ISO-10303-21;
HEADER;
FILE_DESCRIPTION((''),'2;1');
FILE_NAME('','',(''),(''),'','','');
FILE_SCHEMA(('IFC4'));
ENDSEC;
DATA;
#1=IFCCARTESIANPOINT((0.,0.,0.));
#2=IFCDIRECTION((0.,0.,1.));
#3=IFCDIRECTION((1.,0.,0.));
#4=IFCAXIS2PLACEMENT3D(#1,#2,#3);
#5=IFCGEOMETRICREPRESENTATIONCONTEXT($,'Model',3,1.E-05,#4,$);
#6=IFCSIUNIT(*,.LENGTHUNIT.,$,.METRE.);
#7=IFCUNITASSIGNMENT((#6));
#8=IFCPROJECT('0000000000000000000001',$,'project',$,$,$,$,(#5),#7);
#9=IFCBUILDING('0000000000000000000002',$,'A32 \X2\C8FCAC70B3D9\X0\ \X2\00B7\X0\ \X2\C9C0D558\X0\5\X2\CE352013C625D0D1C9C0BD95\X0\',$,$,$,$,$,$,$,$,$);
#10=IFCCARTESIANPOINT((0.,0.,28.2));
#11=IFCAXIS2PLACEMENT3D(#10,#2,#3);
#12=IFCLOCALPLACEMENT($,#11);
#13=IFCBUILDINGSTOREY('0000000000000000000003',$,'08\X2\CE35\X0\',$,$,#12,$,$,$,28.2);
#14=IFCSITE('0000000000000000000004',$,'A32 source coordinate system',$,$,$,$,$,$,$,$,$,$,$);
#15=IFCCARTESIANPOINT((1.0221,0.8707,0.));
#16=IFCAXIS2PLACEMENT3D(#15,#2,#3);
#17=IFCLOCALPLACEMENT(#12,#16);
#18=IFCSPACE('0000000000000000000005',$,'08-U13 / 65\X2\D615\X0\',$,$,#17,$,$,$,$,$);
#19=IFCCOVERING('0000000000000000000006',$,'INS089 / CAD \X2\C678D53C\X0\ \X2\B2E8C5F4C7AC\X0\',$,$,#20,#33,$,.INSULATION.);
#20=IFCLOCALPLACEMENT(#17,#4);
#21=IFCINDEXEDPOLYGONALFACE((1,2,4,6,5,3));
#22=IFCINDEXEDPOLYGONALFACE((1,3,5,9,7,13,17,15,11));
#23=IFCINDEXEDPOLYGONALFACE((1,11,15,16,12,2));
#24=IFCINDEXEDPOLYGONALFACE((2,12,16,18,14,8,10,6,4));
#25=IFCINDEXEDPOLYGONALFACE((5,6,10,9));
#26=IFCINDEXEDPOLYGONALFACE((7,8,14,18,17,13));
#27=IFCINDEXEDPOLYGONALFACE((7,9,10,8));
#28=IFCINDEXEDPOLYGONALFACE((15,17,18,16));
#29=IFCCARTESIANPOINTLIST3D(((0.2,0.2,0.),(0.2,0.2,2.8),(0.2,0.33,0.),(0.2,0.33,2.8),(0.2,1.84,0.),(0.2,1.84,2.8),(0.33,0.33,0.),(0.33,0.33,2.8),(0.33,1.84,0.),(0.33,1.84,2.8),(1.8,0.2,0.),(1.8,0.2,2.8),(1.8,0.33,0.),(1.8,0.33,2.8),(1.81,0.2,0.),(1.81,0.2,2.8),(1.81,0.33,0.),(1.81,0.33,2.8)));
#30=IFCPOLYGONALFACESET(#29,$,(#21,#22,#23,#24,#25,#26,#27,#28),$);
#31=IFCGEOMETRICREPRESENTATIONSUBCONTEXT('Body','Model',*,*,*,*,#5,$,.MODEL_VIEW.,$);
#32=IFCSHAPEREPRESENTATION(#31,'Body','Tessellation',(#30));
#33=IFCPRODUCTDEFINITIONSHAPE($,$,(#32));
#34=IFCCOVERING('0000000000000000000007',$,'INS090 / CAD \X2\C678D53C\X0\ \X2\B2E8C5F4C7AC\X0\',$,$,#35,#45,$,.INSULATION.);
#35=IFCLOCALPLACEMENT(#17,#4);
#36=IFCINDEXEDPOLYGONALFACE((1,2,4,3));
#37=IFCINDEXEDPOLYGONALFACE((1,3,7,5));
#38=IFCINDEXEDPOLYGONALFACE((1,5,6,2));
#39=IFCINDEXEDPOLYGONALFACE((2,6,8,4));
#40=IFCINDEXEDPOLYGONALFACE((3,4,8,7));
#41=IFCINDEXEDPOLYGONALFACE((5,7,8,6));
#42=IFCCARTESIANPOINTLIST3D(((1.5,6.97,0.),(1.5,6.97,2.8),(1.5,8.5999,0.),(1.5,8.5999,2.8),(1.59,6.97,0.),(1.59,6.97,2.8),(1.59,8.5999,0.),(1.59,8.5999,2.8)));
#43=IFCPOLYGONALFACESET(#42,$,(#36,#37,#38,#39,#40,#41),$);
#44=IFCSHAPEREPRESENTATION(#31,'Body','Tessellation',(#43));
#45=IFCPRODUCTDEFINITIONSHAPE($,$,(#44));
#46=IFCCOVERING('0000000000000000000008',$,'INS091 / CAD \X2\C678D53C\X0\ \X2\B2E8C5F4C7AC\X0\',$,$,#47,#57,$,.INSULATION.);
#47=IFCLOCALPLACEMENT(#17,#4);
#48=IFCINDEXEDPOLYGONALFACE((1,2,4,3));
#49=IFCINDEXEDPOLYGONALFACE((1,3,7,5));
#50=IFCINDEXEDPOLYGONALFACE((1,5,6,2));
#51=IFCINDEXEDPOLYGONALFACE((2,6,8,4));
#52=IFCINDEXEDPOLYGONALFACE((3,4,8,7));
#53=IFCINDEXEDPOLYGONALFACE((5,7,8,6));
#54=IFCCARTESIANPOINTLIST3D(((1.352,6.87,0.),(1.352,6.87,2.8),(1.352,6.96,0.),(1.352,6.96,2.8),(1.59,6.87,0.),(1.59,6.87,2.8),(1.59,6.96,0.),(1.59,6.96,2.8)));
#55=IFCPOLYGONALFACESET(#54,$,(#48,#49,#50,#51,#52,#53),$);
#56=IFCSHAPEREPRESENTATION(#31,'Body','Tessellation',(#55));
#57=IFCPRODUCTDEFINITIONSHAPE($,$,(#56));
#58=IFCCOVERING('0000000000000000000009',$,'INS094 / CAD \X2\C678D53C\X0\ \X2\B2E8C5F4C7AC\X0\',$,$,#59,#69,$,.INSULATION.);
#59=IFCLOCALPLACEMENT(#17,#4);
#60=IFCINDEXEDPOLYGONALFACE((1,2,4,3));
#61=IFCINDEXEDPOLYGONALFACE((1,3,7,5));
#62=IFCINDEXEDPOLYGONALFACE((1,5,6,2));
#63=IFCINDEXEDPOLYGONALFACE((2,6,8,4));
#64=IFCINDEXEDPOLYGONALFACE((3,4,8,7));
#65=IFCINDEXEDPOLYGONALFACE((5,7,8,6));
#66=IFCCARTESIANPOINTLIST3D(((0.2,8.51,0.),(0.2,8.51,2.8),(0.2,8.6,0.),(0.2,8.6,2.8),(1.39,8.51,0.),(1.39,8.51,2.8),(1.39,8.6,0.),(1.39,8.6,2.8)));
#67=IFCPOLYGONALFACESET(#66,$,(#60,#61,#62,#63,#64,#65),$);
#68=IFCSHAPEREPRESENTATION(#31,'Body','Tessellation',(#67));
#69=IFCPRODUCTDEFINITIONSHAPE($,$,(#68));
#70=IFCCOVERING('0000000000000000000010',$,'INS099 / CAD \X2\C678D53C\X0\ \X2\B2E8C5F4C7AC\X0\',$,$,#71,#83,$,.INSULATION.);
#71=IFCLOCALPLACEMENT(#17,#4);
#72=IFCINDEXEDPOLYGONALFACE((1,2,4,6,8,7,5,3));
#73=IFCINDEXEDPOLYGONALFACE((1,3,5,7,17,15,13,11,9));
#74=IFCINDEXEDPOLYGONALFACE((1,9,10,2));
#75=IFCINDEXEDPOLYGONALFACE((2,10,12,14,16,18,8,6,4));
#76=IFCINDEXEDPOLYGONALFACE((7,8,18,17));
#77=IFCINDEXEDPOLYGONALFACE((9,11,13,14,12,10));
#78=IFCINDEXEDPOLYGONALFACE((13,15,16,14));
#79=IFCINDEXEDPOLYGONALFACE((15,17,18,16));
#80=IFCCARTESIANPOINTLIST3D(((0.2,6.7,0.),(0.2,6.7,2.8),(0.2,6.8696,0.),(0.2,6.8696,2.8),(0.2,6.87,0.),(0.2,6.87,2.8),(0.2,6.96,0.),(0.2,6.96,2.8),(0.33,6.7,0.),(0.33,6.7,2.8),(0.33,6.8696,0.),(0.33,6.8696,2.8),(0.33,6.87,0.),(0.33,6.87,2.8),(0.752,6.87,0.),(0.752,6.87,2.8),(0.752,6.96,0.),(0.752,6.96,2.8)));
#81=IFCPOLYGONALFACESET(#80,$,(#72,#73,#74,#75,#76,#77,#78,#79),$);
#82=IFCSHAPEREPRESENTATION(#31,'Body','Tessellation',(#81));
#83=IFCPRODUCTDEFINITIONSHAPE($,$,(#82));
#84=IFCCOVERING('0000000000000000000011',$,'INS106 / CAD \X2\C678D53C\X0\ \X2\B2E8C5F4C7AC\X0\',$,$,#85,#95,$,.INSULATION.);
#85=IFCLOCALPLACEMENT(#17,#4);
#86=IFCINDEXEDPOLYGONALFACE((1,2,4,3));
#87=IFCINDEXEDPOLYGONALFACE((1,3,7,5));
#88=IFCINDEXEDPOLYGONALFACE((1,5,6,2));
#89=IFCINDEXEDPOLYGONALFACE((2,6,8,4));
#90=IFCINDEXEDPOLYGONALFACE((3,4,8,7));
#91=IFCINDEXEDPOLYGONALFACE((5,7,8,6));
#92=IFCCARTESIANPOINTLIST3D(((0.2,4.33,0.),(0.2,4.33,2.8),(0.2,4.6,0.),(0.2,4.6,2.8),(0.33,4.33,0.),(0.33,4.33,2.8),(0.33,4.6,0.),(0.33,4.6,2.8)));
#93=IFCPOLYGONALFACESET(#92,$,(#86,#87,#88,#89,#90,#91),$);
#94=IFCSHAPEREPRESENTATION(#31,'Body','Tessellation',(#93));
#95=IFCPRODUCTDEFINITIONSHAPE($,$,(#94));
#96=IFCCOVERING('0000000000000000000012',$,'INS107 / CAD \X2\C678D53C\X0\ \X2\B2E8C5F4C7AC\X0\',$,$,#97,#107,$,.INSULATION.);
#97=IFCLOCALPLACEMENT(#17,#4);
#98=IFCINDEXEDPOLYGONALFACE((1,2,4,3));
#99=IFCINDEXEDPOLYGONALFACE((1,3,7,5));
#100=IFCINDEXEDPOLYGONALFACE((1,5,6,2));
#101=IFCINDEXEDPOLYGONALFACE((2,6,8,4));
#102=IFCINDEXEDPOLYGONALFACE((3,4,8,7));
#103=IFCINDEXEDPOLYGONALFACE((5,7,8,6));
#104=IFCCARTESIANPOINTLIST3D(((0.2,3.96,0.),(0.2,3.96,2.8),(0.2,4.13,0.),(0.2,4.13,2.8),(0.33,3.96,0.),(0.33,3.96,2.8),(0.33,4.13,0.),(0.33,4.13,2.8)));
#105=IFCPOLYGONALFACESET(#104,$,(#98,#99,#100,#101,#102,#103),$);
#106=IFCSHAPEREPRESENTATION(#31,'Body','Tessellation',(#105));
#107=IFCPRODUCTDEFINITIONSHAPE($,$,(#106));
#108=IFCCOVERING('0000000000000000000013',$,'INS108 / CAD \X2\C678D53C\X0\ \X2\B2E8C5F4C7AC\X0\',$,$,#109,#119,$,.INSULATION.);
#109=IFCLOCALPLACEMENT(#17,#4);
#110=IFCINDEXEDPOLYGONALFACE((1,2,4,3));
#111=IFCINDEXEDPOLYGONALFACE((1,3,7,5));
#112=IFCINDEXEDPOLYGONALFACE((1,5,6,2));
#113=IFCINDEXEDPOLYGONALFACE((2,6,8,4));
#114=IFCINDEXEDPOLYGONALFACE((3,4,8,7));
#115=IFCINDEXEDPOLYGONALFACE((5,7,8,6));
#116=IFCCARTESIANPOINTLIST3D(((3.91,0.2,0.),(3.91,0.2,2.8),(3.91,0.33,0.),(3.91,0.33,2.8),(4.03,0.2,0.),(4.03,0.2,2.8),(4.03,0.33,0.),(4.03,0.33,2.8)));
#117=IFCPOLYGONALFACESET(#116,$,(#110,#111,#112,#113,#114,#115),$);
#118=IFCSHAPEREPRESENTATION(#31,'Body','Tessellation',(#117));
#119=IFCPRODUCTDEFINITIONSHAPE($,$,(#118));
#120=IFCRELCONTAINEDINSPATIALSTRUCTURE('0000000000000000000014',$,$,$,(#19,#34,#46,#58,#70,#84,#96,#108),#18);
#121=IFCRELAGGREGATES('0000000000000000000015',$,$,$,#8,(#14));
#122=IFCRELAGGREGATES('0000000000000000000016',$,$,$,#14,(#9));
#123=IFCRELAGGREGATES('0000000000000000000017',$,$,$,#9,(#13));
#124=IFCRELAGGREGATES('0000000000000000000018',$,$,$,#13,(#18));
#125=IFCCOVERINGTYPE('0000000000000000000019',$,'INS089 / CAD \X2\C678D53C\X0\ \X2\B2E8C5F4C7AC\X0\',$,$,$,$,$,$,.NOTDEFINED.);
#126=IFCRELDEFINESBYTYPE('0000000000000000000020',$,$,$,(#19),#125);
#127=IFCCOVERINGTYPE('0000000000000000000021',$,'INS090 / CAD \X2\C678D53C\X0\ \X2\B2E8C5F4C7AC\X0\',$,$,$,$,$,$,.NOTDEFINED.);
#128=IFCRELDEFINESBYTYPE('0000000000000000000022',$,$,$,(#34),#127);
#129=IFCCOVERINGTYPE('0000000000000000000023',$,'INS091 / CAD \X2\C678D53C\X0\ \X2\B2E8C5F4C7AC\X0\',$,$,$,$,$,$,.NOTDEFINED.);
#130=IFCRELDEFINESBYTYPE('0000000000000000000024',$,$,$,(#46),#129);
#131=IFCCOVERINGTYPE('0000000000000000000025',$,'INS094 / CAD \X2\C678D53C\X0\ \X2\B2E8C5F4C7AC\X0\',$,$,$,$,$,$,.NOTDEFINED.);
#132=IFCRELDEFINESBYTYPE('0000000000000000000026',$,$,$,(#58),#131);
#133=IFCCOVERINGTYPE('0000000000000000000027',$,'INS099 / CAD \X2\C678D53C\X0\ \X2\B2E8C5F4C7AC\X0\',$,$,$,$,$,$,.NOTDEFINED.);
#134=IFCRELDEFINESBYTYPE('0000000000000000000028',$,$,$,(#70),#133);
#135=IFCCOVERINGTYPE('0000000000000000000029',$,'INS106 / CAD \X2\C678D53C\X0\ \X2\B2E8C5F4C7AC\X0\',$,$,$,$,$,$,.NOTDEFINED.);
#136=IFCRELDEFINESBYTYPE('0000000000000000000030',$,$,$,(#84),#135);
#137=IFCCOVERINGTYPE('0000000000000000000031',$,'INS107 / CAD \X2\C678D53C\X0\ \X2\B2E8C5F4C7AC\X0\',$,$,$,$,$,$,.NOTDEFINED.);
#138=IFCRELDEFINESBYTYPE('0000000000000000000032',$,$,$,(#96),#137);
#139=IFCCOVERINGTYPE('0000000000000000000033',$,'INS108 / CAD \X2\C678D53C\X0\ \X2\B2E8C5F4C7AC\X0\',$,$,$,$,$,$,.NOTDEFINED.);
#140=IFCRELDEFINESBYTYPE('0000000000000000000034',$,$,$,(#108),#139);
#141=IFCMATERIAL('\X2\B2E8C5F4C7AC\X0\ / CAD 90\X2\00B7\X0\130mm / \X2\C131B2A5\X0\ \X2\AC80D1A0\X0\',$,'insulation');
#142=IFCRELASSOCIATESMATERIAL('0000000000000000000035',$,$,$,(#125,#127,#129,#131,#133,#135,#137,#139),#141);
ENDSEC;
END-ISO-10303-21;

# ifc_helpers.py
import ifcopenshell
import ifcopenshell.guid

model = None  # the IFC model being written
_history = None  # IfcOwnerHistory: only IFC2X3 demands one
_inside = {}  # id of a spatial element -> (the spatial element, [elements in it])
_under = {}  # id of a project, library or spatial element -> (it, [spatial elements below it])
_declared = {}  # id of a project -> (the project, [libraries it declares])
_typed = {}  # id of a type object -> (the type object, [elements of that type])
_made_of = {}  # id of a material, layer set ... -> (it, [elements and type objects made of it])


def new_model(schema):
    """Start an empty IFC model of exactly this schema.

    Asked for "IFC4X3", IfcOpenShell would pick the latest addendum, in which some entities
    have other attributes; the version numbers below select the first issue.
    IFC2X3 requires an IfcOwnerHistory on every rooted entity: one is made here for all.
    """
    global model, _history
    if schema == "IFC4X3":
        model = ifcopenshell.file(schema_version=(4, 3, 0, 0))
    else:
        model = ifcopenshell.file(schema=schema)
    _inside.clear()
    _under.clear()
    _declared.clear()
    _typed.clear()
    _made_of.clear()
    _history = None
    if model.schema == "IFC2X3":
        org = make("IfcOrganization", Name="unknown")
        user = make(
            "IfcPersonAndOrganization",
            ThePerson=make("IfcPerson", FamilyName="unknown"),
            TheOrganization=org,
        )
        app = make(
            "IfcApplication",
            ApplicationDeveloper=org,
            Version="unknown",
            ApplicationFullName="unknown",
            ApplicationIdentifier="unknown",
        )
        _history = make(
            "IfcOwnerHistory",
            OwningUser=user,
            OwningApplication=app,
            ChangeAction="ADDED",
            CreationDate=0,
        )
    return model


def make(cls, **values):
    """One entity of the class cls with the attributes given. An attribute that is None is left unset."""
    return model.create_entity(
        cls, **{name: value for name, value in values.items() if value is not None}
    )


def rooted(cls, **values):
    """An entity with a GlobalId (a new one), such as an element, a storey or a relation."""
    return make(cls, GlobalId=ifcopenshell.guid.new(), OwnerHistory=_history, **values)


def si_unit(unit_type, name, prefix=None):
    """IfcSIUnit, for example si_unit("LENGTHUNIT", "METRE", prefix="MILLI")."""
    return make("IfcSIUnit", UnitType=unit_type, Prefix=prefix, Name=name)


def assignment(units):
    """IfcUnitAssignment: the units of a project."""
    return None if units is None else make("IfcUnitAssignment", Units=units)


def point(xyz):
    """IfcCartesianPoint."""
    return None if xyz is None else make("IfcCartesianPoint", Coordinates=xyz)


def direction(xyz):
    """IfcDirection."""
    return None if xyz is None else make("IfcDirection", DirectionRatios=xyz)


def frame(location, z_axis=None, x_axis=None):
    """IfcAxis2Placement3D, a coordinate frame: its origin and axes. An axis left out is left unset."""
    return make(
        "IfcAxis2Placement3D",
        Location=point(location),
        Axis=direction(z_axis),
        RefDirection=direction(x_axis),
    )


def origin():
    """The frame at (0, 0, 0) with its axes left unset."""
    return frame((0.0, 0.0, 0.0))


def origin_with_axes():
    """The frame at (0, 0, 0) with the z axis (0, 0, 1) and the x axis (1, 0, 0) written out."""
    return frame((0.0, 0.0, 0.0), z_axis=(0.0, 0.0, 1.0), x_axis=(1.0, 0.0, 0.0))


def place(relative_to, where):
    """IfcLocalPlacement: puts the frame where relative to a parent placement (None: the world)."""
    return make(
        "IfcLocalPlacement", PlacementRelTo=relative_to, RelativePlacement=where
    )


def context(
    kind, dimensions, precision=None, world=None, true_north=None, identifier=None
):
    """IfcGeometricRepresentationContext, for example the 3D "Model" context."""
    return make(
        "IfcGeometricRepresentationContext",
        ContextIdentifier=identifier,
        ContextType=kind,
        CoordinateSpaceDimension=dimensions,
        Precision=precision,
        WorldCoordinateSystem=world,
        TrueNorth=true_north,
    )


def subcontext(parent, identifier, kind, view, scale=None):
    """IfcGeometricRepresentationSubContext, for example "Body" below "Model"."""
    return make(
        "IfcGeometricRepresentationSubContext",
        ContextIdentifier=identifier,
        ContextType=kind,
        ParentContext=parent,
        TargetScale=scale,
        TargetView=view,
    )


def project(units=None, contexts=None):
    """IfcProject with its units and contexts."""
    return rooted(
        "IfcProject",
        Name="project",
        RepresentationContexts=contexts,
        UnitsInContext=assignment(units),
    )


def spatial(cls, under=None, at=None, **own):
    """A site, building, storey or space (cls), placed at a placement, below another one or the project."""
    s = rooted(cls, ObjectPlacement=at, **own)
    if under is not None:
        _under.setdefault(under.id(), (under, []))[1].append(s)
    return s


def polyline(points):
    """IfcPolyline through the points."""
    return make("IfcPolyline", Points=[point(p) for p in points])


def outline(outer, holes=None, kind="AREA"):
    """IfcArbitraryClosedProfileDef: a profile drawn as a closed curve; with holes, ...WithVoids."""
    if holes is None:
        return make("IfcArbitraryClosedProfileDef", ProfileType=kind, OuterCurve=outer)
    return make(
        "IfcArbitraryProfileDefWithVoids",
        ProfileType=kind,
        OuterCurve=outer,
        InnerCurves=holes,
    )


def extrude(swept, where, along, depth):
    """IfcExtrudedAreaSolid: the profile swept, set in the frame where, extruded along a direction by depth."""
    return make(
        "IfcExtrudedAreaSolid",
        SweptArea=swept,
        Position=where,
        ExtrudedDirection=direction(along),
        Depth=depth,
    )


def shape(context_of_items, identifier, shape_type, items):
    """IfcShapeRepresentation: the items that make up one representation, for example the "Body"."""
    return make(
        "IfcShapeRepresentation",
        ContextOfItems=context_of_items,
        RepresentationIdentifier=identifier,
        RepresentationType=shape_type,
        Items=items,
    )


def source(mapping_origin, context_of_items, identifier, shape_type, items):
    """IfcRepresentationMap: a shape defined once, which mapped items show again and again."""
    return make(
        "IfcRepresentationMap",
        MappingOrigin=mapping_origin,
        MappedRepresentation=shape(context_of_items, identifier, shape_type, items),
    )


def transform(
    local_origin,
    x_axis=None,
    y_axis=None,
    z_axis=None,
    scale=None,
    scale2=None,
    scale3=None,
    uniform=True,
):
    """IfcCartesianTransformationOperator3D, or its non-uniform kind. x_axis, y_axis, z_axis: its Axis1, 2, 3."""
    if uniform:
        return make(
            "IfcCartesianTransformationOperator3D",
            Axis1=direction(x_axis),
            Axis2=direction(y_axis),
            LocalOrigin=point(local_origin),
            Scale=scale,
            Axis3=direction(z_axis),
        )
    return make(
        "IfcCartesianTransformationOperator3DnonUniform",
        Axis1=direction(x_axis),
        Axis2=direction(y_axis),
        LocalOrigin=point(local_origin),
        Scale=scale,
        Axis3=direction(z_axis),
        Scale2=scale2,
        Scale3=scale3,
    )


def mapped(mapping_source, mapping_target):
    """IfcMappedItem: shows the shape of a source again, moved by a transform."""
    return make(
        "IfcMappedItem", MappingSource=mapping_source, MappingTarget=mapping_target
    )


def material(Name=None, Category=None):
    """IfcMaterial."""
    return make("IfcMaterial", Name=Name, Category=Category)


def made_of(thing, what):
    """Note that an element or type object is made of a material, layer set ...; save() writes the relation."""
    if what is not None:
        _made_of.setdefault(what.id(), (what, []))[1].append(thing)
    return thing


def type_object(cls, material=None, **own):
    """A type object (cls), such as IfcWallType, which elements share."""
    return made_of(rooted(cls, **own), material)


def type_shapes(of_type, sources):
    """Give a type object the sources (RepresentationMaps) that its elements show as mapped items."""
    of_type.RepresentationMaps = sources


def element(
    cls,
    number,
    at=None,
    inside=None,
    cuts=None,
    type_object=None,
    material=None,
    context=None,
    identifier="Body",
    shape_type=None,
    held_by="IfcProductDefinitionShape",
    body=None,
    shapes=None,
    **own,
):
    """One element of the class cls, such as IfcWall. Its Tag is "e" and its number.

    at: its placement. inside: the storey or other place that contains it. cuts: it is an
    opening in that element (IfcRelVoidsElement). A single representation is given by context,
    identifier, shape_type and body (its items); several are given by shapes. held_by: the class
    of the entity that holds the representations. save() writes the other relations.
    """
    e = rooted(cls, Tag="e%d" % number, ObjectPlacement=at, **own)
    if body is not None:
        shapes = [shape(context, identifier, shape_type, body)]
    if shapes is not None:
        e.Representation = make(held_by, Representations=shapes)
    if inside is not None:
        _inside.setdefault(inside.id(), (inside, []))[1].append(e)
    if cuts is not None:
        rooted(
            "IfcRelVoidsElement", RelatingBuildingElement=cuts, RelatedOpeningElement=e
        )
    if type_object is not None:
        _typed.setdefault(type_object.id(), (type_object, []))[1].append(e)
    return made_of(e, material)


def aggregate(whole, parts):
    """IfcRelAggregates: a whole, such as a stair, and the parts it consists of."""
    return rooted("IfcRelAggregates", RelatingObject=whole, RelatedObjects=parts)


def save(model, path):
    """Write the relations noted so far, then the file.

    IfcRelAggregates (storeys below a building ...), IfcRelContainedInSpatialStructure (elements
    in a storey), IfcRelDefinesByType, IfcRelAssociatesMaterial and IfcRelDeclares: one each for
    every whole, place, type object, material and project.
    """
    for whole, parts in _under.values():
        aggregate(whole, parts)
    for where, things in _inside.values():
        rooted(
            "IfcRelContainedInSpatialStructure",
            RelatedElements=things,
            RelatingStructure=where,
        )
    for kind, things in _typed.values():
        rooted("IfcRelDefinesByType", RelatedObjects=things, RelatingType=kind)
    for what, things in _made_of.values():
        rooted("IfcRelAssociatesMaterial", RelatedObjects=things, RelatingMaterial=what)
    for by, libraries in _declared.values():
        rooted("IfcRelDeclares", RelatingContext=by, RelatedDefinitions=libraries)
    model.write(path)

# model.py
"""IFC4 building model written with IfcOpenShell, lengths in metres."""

from ifc_helpers import new_model, si_unit, frame, origin, origin_with_axes, place, context, subcontext, project, spatial, polyline, outline, extrude, source, transform, mapped, material, type_object, type_shapes, element, save


model = new_model("IFC4")

# Units and contexts
model_context = context("Model", 3, precision=1e-05, world=origin_with_axes())
body_context = subcontext(model_context, "Body", "Model", "MODEL_VIEW")
ifc_project = project(units=[si_unit("LENGTHUNIT", "METRE")], contexts=[model_context])

# Site, building, storey
site = spatial("IfcSite", under=ifc_project, Name="A32 source coordinate system")
building = spatial("IfcBuilding", under=site, Name="A32 주거동 · 지하5층–옥탑지붕")
storey_placement = place(None, frame((0.0, 0.0, 28.2), z_axis=(0.0, 0.0, 1.0), x_axis=(1.0, 0.0, 0.0)))
storey = spatial("IfcBuildingStorey", under=building, at=storey_placement, Name="08층", Elevation=28.2)

# Shared definitions
space_placement = place(storey_placement, frame((1.0221, 0.8707, 0.0), z_axis=(0.0, 0.0, 1.0), x_axis=(1.0, 0.0, 0.0)))
space = spatial("IfcSpace", under=storey, at=space_placement, Name="08-U13 / 65형")

# Coverings
ifc_material = material(Name="단열재 / CAD 90·130mm / 성능 검토", Category="insulation")
covering_type_1 = type_object("IfcCoveringType", Name="INS089 / CAD 외피 단열재", PredefinedType="NOTDEFINED", material=ifc_material)
shared_shape_1 = source(origin(), body_context, "Body", "SweptSolid", [
    extrude(outline(polyline([(0.2, 0.33), (0.2, 1.84), (0.33, 1.84), (0.33, 0.33), (1.8, 0.33), (1.81, 0.33), (1.81, 0.2), (1.8, 0.2), (0.2, 0.2), (0.2, 0.33)])), origin(), (0.0, 0.0, 1.0), 2.8),
])
type_shapes(covering_type_1, [shared_shape_1])
covering_1_placement = place(space_placement, origin_with_axes())
element("IfcCovering", 1, at=covering_1_placement, inside=space, type_object=covering_type_1, Name="INS089 / CAD 외피 단열재", PredefinedType="INSULATION", context=body_context, shape_type="MappedRepresentation", body=[
    mapped(shared_shape_1, transform((0.0, 0.0, 0.0), scale=1.0)),
])
covering_type_2 = type_object("IfcCoveringType", Name="INS090 / CAD 외피 단열재", PredefinedType="NOTDEFINED", material=ifc_material)
shared_shape_2 = source(origin(), body_context, "Body", "SweptSolid", [
    extrude(outline(polyline([(1.59, 6.97), (1.5, 6.97), (1.5, 8.5999), (1.59, 8.5999), (1.59, 6.97)])), origin(), (0.0, 0.0, 1.0), 2.8),
])
type_shapes(covering_type_2, [shared_shape_2])
covering_2_placement = place(space_placement, origin_with_axes())
element("IfcCovering", 2, at=covering_2_placement, inside=space, type_object=covering_type_2, Name="INS090 / CAD 외피 단열재", PredefinedType="INSULATION", context=body_context, shape_type="MappedRepresentation", body=[
    mapped(shared_shape_2, transform((0.0, 0.0, 0.0), scale=1.0)),
])
covering_type_3 = type_object("IfcCoveringType", Name="INS091 / CAD 외피 단열재", PredefinedType="NOTDEFINED", material=ifc_material)
shared_shape_3 = source(origin(), body_context, "Body", "SweptSolid", [
    extrude(outline(polyline([(1.59, 6.96), (1.59, 6.87), (1.352, 6.87), (1.352, 6.96), (1.59, 6.96)])), origin(), (0.0, 0.0, 1.0), 2.8),
])
type_shapes(covering_type_3, [shared_shape_3])
covering_3_placement = place(space_placement, origin_with_axes())
element("IfcCovering", 3, at=covering_3_placement, inside=space, type_object=covering_type_3, Name="INS091 / CAD 외피 단열재", PredefinedType="INSULATION", context=body_context, shape_type="MappedRepresentation", body=[
    mapped(shared_shape_3, transform((0.0, 0.0, 0.0), scale=1.0)),
])
covering_type_4 = type_object("IfcCoveringType", Name="INS094 / CAD 외피 단열재", PredefinedType="NOTDEFINED", material=ifc_material)
shared_shape_4 = source(origin(), body_context, "Body", "SweptSolid", [
    extrude(outline(polyline([(1.39, 8.51), (0.2, 8.51), (0.2, 8.6), (1.39, 8.6), (1.39, 8.51)])), origin(), (0.0, 0.0, 1.0), 2.8),
])
type_shapes(covering_type_4, [shared_shape_4])
covering_4_placement = place(space_placement, origin_with_axes())
element("IfcCovering", 4, at=covering_4_placement, inside=space, type_object=covering_type_4, Name="INS094 / CAD 외피 단열재", PredefinedType="INSULATION", context=body_context, shape_type="MappedRepresentation", body=[
    mapped(shared_shape_4, transform((0.0, 0.0, 0.0), scale=1.0)),
])
covering_type_5 = type_object("IfcCoveringType", Name="INS099 / CAD 외피 단열재", PredefinedType="NOTDEFINED", material=ifc_material)
shared_shape_5 = source(origin(), body_context, "Body", "SweptSolid", [
    extrude(outline(polyline([(0.2, 6.8696), (0.2, 6.87), (0.2, 6.96), (0.752, 6.96), (0.752, 6.87), (0.33, 6.87), (0.33, 6.8696), (0.33, 6.7), (0.2, 6.7), (0.2, 6.8696)])), origin(), (0.0, 0.0, 1.0), 2.8),
])
type_shapes(covering_type_5, [shared_shape_5])
covering_5_placement = place(space_placement, origin_with_axes())
element("IfcCovering", 5, at=covering_5_placement, inside=space, type_object=covering_type_5, Name="INS099 / CAD 외피 단열재", PredefinedType="INSULATION", context=body_context, shape_type="MappedRepresentation", body=[
    mapped(shared_shape_5, transform((0.0, 0.0, 0.0), scale=1.0)),
])
covering_type_6 = type_object("IfcCoveringType", Name="INS106 / CAD 외피 단열재", PredefinedType="NOTDEFINED", material=ifc_material)
shared_shape_6 = source(origin(), body_context, "Body", "SweptSolid", [
    extrude(outline(polyline([(0.33, 4.6), (0.33, 4.33), (0.2, 4.33), (0.2, 4.6), (0.33, 4.6)])), origin(), (0.0, 0.0, 1.0), 2.8),
])
type_shapes(covering_type_6, [shared_shape_6])
covering_6_placement = place(space_placement, origin_with_axes())
element("IfcCovering", 6, at=covering_6_placement, inside=space, type_object=covering_type_6, Name="INS106 / CAD 외피 단열재", PredefinedType="INSULATION", context=body_context, shape_type="MappedRepresentation", body=[
    mapped(shared_shape_6, transform((0.0, 0.0, 0.0), scale=1.0)),
])
covering_type_7 = type_object("IfcCoveringType", Name="INS107 / CAD 외피 단열재", PredefinedType="NOTDEFINED", material=ifc_material)
shared_shape_7 = source(origin(), body_context, "Body", "SweptSolid", [
    extrude(outline(polyline([(0.33, 3.96), (0.2, 3.96), (0.2, 4.13), (0.33, 4.13), (0.33, 3.96)])), origin(), (0.0, 0.0, 1.0), 2.8),
])
type_shapes(covering_type_7, [shared_shape_7])
covering_7_placement = place(space_placement, origin_with_axes())
element("IfcCovering", 7, at=covering_7_placement, inside=space, type_object=covering_type_7, Name="INS107 / CAD 외피 단열재", PredefinedType="INSULATION", context=body_context, shape_type="MappedRepresentation", body=[
    mapped(shared_shape_7, transform((0.0, 0.0, 0.0), scale=1.0)),
])
covering_type_8 = type_object("IfcCoveringType", Name="INS108 / CAD 외피 단열재", PredefinedType="NOTDEFINED", material=ifc_material)
shared_shape_8 = source(origin(), body_context, "Body", "SweptSolid", [
    extrude(outline(polyline([(4.03, 0.2), (3.91, 0.2), (3.91, 0.33), (4.03, 0.33), (4.03, 0.2)])), origin(), (0.0, 0.0, 1.0), 2.8),
])
type_shapes(covering_type_8, [shared_shape_8])
covering_8_placement = place(space_placement, origin_with_axes())
element("IfcCovering", 8, at=covering_8_placement, inside=space, type_object=covering_type_8, Name="INS108 / CAD 외피 단열재", PredefinedType="INSULATION", context=body_context, shape_type="MappedRepresentation", body=[
    mapped(shared_shape_8, transform((0.0, 0.0, 0.0), scale=1.0)),
])

save(model, "model.ifc")
